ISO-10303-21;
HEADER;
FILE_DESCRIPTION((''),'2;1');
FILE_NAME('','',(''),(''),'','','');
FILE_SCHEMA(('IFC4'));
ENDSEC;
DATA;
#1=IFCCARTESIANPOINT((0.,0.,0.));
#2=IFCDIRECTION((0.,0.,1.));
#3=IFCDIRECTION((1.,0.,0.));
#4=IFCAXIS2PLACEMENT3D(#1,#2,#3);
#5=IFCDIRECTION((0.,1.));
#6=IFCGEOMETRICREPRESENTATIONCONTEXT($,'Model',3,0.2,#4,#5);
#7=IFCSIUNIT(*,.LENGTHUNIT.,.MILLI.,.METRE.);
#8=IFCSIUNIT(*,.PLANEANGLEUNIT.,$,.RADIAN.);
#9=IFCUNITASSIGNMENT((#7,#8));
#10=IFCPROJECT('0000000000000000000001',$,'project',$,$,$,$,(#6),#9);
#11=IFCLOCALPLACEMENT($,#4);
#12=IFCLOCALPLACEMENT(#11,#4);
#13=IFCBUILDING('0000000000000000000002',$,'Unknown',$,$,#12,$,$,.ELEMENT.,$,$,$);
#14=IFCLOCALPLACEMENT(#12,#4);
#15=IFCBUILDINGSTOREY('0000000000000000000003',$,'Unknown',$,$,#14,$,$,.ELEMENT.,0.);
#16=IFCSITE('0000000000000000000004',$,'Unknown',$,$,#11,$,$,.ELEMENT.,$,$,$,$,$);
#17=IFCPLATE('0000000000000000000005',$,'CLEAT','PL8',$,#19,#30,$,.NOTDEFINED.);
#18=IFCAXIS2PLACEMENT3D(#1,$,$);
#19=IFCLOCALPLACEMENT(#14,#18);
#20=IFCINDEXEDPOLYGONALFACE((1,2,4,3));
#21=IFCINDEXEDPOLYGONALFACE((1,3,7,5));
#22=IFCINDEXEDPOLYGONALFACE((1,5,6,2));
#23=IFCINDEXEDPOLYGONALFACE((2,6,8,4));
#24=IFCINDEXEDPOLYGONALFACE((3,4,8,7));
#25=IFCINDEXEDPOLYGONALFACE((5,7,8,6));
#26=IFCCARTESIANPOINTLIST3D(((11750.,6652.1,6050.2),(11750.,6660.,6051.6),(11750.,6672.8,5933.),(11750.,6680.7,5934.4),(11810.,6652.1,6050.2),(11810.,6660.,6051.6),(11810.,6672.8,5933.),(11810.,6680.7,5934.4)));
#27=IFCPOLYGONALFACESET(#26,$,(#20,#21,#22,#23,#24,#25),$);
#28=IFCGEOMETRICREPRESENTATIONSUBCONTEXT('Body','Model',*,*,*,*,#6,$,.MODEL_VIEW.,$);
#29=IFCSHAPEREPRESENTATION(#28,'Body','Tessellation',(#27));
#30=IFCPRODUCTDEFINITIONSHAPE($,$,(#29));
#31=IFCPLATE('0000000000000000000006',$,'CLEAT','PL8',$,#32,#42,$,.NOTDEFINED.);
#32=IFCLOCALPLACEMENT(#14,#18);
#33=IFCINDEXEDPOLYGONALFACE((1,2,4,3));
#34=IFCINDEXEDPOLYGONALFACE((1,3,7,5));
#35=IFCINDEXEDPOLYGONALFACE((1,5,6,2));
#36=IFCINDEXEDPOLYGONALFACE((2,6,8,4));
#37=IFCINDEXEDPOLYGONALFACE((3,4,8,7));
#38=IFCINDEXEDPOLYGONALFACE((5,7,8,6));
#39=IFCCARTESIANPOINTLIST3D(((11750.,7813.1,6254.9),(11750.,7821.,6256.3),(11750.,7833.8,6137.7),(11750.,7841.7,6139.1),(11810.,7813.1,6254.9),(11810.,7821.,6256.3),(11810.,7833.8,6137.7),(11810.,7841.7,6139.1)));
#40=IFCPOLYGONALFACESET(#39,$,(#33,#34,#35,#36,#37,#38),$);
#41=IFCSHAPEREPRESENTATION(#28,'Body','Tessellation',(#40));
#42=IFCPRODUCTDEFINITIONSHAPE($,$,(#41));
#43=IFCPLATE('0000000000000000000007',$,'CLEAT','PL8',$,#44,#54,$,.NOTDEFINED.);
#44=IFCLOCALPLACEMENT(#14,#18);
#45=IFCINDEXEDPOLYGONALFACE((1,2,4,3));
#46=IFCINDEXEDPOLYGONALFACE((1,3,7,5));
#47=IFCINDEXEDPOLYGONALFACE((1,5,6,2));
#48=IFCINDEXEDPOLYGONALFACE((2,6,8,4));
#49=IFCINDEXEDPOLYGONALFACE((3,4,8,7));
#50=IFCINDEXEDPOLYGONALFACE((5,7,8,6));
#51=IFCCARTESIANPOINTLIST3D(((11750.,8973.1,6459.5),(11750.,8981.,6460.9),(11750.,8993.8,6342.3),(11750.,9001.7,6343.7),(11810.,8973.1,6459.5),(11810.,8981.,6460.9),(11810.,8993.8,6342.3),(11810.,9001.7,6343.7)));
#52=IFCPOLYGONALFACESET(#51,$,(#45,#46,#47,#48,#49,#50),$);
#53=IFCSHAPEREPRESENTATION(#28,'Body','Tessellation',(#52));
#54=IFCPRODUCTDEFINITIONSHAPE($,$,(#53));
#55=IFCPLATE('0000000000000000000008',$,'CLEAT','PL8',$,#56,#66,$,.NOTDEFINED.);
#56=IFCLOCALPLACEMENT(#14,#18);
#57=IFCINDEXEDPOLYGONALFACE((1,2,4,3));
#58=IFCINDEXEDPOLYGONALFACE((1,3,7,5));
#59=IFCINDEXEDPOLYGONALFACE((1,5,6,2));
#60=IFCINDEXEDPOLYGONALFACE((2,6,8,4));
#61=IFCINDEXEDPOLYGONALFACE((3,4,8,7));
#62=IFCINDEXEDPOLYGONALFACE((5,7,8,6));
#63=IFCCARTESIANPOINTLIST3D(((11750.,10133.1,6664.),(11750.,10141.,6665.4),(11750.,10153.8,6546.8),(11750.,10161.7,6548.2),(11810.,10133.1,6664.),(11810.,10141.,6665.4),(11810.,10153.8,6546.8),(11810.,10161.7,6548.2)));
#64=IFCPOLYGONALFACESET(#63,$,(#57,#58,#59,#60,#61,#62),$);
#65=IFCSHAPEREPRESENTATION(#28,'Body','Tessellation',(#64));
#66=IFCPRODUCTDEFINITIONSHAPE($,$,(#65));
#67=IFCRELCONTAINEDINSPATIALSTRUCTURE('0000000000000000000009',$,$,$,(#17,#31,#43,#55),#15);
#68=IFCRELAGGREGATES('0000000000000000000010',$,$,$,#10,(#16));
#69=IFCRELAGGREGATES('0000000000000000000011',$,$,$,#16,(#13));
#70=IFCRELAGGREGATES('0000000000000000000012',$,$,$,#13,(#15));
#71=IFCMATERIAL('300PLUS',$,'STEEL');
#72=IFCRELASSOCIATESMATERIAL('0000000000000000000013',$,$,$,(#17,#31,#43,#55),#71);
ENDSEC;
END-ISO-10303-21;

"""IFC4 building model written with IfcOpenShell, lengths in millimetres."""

from ifc_helpers import new_model, si_unit, direction, frame, origin_with_axes, place, context, subcontext, project, spatial, line, indexed_curve, outline, extrude, material, element, save


model = new_model("IFC4")

# Units and contexts
model_context = context("Model", 3, precision=0.2, world=origin_with_axes(), true_north=direction((0.0, 1.0)))
body_context = subcontext(model_context, "Body", "Model", "MODEL_VIEW")
ifc_project = project(units=[si_unit("LENGTHUNIT", "METRE", prefix="MILLI"), si_unit("PLANEANGLEUNIT", "RADIAN")], contexts=[model_context])

# Site, building, storey
site_placement = place(None, origin_with_axes())
site = spatial("IfcSite", under=ifc_project, at=site_placement, Name="Unknown", CompositionType="ELEMENT")
building_placement = place(site_placement, origin_with_axes())
building = spatial("IfcBuilding", under=site, at=building_placement, Name="Unknown", CompositionType="ELEMENT")
storey_placement = place(building_placement, origin_with_axes())
storey = spatial("IfcBuildingStorey", under=building, at=storey_placement, Name="Unknown", CompositionType="ELEMENT", Elevation=0.0)

# Shared definitions
ifc_material_1 = material(Name="300PLUS", Category="STEEL")

# Plates
for number, where, z_axis, x_axis, name in (
    (1, (11810.0, 6676.7, 5933.7), (0.0, 0.984758, 0.173929), (-1.0, 0.0, 0.0), "CLEAT"),
    (2, (11810.0, 7837.7, 6138.4), (0.0, 0.984758, 0.173929), (-1.0, 0.0, 0.0), "CLEAT"),
    (3, (11810.0, 8997.7, 6343.0), (0.0, 0.984758, 0.173929), (-1.0, 0.0, 0.0), "CLEAT"),
    (4, (11810.0, 10157.7, 6547.5), (0.0, 0.984758, 0.173929), (-1.0, 0.0, 0.0), "CLEAT"),
):
    element("IfcPlate", number, at=place(storey_placement, frame(where, z_axis=z_axis, x_axis=x_axis)), inside=storey, material=ifc_material_1, Name=name, Description="PL8", PredefinedType="NOTDEFINED", context=body_context, shape_type="SolidModel", body=[
        extrude(outline(indexed_curve([(0.0, 0.0), (60.0, 0.0), (60.0, 119.0), (0.0, 119.0)], segments=[line(1, 2, 3, 4, 1)])), frame((0.0, 0.0, 4.0), z_axis=(0.0, 0.0, 1.0), x_axis=(1.0, 0.0, 0.0)), (0.0, 0.0, -1.0), 8.0),
    ])

save(model, "model.ifc")
